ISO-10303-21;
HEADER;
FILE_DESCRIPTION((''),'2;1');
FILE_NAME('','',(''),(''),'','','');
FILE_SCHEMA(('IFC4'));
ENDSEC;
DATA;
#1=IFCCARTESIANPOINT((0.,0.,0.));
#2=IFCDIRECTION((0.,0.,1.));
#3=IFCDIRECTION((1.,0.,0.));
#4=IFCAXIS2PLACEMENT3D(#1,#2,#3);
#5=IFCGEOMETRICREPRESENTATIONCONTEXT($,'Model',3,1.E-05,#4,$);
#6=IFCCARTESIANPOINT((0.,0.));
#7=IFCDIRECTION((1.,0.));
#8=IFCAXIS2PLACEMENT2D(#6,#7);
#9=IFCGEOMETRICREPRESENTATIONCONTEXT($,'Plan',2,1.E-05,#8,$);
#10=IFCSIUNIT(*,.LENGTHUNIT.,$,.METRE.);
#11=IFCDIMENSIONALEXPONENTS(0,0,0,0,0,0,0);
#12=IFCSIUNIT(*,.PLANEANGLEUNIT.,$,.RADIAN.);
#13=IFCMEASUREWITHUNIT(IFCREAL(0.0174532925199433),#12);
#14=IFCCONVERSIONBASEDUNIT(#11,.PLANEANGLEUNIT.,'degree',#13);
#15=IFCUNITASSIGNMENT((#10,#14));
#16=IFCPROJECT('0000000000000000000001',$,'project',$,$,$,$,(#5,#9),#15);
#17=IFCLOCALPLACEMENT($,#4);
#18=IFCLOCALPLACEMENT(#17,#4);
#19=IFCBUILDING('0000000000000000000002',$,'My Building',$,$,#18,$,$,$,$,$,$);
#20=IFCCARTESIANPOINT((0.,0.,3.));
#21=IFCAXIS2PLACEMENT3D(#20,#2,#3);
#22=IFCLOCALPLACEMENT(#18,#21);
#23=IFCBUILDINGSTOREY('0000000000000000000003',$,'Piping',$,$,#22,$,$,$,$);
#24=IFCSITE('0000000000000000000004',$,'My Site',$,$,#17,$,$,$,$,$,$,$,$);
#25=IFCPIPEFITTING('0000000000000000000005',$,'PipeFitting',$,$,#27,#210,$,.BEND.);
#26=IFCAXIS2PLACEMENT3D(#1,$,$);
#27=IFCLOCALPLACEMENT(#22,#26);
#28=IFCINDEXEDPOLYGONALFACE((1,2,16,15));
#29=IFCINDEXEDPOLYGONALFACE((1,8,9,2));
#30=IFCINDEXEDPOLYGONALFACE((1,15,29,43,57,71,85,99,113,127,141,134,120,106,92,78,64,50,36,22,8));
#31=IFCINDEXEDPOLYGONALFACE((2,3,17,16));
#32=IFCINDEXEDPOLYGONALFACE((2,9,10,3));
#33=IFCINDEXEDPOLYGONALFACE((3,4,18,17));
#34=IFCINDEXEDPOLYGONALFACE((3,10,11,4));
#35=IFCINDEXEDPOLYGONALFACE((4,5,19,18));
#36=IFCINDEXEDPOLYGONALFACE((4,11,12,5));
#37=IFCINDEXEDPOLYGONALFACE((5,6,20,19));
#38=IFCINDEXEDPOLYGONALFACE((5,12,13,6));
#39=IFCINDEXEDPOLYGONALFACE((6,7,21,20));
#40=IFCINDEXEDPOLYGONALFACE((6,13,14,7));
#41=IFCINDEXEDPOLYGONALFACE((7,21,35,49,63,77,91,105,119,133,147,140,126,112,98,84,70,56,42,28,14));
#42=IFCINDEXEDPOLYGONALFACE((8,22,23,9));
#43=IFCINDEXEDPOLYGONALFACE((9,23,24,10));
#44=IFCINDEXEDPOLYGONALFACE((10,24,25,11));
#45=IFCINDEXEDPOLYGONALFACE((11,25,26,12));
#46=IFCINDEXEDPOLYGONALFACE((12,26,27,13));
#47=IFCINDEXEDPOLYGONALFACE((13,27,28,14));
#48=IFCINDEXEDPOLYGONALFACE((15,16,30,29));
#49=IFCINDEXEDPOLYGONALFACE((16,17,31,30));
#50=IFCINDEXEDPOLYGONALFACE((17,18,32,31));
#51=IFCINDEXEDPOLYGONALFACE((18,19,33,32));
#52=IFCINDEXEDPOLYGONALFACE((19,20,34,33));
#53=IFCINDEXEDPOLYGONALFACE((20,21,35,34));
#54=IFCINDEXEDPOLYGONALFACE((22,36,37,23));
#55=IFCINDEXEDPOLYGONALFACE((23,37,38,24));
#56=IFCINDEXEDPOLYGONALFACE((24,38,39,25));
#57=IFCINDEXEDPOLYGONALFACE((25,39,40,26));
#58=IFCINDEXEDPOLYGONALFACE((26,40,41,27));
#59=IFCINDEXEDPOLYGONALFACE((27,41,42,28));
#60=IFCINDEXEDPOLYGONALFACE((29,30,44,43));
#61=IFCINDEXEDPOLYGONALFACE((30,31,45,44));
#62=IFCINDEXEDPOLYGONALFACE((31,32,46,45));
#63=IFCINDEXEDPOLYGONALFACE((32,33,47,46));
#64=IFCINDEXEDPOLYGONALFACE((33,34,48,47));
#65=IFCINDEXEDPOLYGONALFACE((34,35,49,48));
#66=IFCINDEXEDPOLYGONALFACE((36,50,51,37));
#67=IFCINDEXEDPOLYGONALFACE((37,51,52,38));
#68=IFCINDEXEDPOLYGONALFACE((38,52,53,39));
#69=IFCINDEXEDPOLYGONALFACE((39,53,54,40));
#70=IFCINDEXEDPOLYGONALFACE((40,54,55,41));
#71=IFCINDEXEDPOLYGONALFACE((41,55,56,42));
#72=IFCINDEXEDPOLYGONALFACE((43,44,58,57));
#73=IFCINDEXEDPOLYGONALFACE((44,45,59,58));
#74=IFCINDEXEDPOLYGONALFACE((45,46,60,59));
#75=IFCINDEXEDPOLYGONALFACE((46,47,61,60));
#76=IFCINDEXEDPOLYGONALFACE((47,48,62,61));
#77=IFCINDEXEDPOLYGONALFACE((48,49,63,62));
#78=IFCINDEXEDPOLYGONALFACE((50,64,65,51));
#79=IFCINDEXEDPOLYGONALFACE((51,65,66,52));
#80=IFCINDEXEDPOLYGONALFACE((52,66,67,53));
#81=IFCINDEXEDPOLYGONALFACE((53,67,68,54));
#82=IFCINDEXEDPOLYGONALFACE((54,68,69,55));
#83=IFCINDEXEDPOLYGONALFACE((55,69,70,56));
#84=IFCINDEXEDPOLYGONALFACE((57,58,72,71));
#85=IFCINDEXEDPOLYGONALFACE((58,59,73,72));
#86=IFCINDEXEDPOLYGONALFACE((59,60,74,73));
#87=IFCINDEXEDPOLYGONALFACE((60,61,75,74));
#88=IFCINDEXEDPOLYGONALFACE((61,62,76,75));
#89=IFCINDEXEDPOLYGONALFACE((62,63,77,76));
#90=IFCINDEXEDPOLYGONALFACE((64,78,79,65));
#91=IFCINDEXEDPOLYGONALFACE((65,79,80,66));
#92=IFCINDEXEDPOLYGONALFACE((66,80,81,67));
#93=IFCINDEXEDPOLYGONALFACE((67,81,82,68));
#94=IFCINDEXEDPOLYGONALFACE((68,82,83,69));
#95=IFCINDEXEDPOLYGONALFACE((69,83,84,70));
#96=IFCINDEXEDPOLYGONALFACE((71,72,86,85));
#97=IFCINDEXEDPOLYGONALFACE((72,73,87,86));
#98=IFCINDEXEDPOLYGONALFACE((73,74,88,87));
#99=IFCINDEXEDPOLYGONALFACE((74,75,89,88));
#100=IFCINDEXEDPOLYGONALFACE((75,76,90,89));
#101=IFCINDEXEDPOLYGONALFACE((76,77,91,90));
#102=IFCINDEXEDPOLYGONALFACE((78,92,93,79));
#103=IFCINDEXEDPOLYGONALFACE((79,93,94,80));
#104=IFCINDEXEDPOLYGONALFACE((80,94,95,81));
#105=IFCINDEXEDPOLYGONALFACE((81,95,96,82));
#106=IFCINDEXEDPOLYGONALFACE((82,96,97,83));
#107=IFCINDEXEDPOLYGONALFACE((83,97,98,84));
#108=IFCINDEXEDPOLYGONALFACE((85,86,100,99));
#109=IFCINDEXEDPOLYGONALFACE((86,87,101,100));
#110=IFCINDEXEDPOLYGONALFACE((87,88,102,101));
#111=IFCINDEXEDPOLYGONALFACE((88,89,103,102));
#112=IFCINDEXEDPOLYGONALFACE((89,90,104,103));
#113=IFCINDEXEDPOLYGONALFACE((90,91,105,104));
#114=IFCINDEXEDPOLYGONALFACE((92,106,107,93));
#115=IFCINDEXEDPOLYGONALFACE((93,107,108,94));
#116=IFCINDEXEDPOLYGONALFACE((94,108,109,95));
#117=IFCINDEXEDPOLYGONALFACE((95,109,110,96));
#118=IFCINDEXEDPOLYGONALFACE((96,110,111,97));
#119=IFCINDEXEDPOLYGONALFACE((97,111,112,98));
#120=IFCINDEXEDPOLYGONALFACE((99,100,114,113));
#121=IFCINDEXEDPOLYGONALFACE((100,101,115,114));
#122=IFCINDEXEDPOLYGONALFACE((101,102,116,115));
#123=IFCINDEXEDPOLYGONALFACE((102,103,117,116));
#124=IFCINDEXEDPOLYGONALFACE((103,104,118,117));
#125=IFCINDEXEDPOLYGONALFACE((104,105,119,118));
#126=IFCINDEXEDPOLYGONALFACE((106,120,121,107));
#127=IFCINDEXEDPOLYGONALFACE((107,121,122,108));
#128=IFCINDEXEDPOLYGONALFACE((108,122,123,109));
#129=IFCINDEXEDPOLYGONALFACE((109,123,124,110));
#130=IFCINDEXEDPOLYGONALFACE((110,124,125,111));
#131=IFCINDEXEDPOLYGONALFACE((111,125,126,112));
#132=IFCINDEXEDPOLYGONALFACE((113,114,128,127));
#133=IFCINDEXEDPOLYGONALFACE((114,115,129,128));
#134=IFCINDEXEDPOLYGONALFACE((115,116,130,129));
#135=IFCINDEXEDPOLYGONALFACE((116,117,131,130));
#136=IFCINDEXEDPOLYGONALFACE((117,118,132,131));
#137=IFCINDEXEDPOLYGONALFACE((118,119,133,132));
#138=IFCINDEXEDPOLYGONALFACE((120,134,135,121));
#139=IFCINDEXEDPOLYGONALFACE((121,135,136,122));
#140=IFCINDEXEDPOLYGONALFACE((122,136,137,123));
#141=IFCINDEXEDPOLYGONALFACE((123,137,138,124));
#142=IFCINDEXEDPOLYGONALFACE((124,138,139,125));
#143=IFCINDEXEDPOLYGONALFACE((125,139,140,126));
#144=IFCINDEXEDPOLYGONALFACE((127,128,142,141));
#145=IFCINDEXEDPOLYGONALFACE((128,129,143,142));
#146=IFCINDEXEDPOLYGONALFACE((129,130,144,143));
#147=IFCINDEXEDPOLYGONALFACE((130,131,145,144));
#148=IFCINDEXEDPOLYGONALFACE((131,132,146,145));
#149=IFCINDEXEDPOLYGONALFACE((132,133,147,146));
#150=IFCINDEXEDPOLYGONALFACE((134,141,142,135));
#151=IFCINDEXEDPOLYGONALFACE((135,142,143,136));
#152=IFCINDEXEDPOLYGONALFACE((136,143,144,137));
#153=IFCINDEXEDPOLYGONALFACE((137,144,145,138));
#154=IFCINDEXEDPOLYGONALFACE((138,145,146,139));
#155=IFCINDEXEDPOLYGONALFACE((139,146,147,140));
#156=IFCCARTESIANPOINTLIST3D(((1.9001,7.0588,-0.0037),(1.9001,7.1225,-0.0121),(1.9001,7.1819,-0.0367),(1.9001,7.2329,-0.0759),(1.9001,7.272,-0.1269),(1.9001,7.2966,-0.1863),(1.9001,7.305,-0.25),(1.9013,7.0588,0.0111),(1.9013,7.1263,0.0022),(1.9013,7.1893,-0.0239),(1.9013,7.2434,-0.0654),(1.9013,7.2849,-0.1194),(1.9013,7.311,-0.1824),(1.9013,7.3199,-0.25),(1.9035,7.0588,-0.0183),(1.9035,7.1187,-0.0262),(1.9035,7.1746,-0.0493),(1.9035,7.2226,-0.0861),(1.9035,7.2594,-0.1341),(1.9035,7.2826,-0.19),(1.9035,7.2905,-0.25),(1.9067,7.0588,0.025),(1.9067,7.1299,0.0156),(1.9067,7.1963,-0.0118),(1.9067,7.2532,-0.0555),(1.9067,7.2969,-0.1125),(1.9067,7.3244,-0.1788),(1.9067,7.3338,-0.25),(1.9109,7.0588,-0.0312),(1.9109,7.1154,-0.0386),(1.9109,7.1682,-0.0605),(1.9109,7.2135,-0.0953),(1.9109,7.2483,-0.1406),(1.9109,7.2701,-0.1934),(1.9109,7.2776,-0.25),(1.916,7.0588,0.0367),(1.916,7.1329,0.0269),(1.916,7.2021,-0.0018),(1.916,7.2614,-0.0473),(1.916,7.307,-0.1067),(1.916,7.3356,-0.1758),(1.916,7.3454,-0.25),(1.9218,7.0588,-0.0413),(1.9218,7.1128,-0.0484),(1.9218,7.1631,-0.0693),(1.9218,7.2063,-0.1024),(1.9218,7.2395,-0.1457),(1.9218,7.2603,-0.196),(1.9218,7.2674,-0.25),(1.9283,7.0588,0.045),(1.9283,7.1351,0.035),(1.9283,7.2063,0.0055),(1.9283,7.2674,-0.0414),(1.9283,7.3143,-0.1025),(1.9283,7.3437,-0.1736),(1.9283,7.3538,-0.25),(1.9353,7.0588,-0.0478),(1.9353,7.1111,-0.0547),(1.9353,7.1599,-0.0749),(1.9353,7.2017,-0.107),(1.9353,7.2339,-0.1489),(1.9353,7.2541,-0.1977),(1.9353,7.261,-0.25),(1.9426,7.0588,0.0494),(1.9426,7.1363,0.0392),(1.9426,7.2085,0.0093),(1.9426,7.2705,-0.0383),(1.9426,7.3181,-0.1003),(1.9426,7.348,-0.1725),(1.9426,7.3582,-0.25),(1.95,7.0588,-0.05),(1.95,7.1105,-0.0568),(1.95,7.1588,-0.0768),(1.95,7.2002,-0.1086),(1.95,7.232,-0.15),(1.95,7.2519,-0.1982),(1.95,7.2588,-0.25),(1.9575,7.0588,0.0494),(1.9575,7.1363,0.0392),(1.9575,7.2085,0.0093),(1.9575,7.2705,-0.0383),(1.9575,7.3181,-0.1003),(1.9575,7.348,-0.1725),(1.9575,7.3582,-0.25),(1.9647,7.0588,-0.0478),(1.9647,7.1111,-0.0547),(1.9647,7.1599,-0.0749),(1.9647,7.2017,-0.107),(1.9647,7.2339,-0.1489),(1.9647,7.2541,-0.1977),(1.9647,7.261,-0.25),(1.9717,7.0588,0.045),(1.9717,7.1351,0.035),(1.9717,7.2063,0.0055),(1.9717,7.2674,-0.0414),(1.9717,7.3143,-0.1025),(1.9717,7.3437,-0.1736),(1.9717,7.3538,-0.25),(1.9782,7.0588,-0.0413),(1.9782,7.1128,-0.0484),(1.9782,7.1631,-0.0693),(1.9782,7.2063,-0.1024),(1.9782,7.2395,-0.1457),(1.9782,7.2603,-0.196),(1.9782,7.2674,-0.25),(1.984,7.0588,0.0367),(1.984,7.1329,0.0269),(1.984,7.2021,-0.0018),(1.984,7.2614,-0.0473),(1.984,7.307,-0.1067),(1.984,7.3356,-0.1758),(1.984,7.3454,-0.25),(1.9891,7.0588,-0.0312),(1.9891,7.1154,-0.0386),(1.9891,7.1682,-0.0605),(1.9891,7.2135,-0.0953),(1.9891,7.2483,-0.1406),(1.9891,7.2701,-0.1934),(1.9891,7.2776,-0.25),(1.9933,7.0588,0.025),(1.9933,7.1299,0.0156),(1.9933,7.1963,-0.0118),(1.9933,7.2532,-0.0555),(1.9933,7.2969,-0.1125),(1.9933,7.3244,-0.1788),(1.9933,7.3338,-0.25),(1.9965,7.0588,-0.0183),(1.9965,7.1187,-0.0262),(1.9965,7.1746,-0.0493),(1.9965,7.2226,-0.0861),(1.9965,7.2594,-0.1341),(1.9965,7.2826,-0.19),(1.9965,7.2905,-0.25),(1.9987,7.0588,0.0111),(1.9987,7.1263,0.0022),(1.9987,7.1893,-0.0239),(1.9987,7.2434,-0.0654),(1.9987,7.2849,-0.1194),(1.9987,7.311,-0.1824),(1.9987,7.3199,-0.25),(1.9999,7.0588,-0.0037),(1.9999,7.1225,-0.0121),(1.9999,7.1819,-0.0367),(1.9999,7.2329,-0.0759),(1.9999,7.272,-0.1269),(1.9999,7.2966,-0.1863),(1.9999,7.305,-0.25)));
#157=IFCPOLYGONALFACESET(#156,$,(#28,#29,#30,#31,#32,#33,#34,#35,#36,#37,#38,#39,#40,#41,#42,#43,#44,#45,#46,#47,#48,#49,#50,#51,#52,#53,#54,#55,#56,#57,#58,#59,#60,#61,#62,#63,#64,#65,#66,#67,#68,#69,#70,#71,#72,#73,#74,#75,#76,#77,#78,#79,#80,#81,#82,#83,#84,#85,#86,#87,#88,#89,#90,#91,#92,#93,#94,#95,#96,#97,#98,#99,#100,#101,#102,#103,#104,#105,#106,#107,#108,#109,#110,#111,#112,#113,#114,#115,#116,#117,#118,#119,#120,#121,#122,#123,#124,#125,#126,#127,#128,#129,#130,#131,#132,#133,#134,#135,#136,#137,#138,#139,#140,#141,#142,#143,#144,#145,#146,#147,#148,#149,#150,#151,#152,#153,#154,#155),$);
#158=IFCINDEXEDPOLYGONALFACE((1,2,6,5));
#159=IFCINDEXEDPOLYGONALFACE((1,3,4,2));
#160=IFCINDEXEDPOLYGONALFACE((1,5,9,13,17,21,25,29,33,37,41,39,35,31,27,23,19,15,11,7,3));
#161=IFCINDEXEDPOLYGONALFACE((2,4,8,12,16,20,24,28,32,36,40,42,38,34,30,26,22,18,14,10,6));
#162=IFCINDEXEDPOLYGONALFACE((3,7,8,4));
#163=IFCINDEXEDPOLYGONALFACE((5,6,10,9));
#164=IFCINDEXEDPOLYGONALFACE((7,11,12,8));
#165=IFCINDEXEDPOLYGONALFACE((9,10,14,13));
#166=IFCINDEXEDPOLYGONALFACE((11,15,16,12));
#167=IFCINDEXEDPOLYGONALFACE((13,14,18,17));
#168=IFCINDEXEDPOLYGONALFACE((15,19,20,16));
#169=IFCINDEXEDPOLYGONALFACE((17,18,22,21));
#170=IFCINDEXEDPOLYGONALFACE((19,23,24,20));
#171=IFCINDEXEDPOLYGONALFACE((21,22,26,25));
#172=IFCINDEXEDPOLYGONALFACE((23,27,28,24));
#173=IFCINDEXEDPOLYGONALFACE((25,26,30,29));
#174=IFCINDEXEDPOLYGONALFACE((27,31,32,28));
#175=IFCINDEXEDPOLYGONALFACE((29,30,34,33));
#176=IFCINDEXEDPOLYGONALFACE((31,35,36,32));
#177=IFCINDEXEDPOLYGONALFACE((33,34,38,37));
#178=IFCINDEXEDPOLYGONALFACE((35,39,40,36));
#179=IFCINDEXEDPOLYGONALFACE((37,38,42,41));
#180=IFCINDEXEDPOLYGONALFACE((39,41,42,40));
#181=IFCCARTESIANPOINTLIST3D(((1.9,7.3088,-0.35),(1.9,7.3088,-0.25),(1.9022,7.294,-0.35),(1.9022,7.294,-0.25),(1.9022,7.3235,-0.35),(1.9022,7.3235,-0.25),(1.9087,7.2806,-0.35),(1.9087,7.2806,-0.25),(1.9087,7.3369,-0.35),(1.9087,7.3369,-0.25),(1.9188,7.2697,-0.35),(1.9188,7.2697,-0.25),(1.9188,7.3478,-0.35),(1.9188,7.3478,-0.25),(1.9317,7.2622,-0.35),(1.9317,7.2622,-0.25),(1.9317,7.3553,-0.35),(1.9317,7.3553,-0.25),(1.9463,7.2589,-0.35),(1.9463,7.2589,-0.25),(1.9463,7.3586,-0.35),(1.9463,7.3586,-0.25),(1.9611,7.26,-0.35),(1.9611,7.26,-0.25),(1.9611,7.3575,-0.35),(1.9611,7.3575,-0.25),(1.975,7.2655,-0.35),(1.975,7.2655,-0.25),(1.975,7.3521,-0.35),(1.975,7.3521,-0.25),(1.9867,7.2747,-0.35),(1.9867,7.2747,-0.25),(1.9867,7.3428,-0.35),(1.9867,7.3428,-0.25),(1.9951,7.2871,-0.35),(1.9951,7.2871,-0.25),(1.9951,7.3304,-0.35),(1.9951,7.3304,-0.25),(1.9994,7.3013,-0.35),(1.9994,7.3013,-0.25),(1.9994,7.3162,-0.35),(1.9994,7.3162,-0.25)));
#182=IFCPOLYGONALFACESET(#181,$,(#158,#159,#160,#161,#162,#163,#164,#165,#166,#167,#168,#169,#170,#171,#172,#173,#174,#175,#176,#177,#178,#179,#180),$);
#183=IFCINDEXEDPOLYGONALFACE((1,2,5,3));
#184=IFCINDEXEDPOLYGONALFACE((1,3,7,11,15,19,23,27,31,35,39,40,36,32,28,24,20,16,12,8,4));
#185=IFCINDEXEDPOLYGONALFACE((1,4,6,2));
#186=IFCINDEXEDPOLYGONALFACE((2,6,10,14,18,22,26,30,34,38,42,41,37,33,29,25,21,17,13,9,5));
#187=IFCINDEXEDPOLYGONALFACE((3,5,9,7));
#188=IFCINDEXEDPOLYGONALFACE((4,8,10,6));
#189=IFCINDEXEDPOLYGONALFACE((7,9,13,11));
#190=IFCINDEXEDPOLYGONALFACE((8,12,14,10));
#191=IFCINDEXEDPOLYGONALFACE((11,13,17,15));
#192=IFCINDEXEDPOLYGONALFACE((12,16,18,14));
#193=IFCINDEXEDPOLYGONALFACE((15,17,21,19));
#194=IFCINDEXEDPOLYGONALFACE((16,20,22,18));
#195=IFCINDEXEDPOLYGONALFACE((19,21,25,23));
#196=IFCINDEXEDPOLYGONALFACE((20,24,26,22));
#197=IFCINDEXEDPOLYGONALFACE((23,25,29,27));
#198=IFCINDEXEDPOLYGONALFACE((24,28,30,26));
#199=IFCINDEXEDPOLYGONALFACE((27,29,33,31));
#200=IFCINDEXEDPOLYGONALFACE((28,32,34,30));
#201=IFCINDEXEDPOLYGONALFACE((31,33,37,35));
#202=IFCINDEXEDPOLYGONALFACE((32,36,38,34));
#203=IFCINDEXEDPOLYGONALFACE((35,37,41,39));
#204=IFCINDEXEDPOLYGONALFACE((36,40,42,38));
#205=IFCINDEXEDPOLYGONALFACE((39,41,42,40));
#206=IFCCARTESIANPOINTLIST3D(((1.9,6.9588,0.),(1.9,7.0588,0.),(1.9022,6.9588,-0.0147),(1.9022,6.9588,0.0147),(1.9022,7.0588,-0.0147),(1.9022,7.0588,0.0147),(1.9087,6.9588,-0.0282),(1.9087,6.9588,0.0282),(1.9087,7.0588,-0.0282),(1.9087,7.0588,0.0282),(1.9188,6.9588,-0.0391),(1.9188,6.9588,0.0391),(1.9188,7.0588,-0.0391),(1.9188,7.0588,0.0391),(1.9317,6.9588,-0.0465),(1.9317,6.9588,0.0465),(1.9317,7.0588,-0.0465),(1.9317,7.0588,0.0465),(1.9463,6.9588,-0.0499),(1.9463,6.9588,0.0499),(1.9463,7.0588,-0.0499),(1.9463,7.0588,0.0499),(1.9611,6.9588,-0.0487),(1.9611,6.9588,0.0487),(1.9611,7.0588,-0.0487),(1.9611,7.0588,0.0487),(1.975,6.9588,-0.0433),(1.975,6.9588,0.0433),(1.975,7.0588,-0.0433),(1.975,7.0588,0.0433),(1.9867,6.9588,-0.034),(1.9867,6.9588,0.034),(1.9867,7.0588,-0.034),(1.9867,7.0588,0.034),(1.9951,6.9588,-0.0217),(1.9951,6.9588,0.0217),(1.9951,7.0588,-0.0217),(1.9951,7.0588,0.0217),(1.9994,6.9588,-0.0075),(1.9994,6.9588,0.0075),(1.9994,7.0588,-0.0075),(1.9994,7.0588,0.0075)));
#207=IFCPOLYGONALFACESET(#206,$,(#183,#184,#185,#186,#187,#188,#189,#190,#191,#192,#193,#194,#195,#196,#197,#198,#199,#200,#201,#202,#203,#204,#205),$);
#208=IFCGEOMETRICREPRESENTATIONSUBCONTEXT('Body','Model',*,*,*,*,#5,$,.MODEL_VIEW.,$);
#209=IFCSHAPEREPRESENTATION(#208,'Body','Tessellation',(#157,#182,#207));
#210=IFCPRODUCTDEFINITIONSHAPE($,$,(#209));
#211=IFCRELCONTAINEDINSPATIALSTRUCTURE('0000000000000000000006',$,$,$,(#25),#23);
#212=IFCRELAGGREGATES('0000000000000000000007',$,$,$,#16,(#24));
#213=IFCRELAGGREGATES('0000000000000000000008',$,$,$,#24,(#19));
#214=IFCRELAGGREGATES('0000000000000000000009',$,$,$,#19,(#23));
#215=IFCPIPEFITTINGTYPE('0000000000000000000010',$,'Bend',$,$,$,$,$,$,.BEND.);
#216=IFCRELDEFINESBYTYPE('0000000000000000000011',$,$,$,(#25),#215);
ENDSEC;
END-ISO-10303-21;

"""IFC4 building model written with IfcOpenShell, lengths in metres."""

from ifc_helpers import new_model, entity, si_unit, converted_unit, frame, origin_with_axes, origin_2d_with_axis, place, context, subcontext, project, spatial, circle, extrude, source, transform, mapped, type_object, type_shapes, element, save


model = new_model("IFC4")

# Units and contexts
model_context = context("Model", 3, precision=1e-05, world=origin_with_axes())
plan_context = context("Plan", 2, precision=1e-05, world=origin_2d_with_axis())
body_context = subcontext(model_context, "Body", "Model", "MODEL_VIEW")
ifc_project = project(units=[si_unit("LENGTHUNIT", "METRE"), converted_unit("PLANEANGLEUNIT", "degree", entity("IfcReal", 0.0174532925199433), si_unit("PLANEANGLEUNIT", "RADIAN"), dimensions=[0, 0, 0, 0, 0, 0, 0])], contexts=[model_context, plan_context])

# Site, building, storey
site_placement = place(None, origin_with_axes())
site = spatial("IfcSite", under=ifc_project, at=site_placement, Name="My Site")
building_placement = place(site_placement, origin_with_axes())
building = spatial("IfcBuilding", under=site, at=building_placement, Name="My Building")
storey_placement = place(building_placement, frame((0.0, 0.0, 3.0), z_axis=(0.0, 0.0, 1.0), x_axis=(1.0, 0.0, 0.0)))
storey = spatial("IfcBuildingStorey", under=building, at=storey_placement, Name="Piping")

# Pipe fitting
pipe_fitting_type = type_object("IfcPipeFittingType", Name="Bend", PredefinedType="BEND")
shared_shape = source(origin_with_axes(), body_context, "Body", "SolidModel", [
    entity("IfcSweptDiskSolid", entity("IfcIndexedPolyCurve", entity("IfcCartesianPointList3D", [[0.0, 0.0, -0.1], [0.0, -0.0732, -0.2768], [0.0, -0.25, -0.35]]), [entity("IfcArcIndex", [1, 2, 3])]), 0.05),
    extrude(circle(Radius=0.05), origin_with_axes(), (0.0, 0.0, -1.0), 0.1),
    extrude(circle(Radius=0.05), frame((0.0, -0.25, -0.35), z_axis=(0.0, -1.0, 0.0), x_axis=(1.0, 0.0, 0.0)), (0.0, 0.0, 1.0), 0.1),
])
type_shapes(pipe_fitting_type, [shared_shape])
for number, where, z_axis, x_axis, name in (
    (1, (1.95, 7.3088, -0.35), (0.0, 0.0, -1.0), (-1.0, 0.0, 0.0), "PipeFitting"),
):
    element("IfcPipeFitting", number, at=place(storey_placement, frame(where, z_axis=z_axis, x_axis=x_axis)), inside=storey, type_object=pipe_fitting_type, Name=name, PredefinedType="BEND", context=body_context, shape_type="MappedRepresentation", body=[
        mapped(shared_shape, transform((0.0, 0.0, 0.0), x_axis=(1.0, 0.0, 0.0), y_axis=(0.0, 1.0, 0.0), z_axis=(0.0, 0.0, 1.0), scale=1.0)),
    ])

save(model, "model.ifc")
